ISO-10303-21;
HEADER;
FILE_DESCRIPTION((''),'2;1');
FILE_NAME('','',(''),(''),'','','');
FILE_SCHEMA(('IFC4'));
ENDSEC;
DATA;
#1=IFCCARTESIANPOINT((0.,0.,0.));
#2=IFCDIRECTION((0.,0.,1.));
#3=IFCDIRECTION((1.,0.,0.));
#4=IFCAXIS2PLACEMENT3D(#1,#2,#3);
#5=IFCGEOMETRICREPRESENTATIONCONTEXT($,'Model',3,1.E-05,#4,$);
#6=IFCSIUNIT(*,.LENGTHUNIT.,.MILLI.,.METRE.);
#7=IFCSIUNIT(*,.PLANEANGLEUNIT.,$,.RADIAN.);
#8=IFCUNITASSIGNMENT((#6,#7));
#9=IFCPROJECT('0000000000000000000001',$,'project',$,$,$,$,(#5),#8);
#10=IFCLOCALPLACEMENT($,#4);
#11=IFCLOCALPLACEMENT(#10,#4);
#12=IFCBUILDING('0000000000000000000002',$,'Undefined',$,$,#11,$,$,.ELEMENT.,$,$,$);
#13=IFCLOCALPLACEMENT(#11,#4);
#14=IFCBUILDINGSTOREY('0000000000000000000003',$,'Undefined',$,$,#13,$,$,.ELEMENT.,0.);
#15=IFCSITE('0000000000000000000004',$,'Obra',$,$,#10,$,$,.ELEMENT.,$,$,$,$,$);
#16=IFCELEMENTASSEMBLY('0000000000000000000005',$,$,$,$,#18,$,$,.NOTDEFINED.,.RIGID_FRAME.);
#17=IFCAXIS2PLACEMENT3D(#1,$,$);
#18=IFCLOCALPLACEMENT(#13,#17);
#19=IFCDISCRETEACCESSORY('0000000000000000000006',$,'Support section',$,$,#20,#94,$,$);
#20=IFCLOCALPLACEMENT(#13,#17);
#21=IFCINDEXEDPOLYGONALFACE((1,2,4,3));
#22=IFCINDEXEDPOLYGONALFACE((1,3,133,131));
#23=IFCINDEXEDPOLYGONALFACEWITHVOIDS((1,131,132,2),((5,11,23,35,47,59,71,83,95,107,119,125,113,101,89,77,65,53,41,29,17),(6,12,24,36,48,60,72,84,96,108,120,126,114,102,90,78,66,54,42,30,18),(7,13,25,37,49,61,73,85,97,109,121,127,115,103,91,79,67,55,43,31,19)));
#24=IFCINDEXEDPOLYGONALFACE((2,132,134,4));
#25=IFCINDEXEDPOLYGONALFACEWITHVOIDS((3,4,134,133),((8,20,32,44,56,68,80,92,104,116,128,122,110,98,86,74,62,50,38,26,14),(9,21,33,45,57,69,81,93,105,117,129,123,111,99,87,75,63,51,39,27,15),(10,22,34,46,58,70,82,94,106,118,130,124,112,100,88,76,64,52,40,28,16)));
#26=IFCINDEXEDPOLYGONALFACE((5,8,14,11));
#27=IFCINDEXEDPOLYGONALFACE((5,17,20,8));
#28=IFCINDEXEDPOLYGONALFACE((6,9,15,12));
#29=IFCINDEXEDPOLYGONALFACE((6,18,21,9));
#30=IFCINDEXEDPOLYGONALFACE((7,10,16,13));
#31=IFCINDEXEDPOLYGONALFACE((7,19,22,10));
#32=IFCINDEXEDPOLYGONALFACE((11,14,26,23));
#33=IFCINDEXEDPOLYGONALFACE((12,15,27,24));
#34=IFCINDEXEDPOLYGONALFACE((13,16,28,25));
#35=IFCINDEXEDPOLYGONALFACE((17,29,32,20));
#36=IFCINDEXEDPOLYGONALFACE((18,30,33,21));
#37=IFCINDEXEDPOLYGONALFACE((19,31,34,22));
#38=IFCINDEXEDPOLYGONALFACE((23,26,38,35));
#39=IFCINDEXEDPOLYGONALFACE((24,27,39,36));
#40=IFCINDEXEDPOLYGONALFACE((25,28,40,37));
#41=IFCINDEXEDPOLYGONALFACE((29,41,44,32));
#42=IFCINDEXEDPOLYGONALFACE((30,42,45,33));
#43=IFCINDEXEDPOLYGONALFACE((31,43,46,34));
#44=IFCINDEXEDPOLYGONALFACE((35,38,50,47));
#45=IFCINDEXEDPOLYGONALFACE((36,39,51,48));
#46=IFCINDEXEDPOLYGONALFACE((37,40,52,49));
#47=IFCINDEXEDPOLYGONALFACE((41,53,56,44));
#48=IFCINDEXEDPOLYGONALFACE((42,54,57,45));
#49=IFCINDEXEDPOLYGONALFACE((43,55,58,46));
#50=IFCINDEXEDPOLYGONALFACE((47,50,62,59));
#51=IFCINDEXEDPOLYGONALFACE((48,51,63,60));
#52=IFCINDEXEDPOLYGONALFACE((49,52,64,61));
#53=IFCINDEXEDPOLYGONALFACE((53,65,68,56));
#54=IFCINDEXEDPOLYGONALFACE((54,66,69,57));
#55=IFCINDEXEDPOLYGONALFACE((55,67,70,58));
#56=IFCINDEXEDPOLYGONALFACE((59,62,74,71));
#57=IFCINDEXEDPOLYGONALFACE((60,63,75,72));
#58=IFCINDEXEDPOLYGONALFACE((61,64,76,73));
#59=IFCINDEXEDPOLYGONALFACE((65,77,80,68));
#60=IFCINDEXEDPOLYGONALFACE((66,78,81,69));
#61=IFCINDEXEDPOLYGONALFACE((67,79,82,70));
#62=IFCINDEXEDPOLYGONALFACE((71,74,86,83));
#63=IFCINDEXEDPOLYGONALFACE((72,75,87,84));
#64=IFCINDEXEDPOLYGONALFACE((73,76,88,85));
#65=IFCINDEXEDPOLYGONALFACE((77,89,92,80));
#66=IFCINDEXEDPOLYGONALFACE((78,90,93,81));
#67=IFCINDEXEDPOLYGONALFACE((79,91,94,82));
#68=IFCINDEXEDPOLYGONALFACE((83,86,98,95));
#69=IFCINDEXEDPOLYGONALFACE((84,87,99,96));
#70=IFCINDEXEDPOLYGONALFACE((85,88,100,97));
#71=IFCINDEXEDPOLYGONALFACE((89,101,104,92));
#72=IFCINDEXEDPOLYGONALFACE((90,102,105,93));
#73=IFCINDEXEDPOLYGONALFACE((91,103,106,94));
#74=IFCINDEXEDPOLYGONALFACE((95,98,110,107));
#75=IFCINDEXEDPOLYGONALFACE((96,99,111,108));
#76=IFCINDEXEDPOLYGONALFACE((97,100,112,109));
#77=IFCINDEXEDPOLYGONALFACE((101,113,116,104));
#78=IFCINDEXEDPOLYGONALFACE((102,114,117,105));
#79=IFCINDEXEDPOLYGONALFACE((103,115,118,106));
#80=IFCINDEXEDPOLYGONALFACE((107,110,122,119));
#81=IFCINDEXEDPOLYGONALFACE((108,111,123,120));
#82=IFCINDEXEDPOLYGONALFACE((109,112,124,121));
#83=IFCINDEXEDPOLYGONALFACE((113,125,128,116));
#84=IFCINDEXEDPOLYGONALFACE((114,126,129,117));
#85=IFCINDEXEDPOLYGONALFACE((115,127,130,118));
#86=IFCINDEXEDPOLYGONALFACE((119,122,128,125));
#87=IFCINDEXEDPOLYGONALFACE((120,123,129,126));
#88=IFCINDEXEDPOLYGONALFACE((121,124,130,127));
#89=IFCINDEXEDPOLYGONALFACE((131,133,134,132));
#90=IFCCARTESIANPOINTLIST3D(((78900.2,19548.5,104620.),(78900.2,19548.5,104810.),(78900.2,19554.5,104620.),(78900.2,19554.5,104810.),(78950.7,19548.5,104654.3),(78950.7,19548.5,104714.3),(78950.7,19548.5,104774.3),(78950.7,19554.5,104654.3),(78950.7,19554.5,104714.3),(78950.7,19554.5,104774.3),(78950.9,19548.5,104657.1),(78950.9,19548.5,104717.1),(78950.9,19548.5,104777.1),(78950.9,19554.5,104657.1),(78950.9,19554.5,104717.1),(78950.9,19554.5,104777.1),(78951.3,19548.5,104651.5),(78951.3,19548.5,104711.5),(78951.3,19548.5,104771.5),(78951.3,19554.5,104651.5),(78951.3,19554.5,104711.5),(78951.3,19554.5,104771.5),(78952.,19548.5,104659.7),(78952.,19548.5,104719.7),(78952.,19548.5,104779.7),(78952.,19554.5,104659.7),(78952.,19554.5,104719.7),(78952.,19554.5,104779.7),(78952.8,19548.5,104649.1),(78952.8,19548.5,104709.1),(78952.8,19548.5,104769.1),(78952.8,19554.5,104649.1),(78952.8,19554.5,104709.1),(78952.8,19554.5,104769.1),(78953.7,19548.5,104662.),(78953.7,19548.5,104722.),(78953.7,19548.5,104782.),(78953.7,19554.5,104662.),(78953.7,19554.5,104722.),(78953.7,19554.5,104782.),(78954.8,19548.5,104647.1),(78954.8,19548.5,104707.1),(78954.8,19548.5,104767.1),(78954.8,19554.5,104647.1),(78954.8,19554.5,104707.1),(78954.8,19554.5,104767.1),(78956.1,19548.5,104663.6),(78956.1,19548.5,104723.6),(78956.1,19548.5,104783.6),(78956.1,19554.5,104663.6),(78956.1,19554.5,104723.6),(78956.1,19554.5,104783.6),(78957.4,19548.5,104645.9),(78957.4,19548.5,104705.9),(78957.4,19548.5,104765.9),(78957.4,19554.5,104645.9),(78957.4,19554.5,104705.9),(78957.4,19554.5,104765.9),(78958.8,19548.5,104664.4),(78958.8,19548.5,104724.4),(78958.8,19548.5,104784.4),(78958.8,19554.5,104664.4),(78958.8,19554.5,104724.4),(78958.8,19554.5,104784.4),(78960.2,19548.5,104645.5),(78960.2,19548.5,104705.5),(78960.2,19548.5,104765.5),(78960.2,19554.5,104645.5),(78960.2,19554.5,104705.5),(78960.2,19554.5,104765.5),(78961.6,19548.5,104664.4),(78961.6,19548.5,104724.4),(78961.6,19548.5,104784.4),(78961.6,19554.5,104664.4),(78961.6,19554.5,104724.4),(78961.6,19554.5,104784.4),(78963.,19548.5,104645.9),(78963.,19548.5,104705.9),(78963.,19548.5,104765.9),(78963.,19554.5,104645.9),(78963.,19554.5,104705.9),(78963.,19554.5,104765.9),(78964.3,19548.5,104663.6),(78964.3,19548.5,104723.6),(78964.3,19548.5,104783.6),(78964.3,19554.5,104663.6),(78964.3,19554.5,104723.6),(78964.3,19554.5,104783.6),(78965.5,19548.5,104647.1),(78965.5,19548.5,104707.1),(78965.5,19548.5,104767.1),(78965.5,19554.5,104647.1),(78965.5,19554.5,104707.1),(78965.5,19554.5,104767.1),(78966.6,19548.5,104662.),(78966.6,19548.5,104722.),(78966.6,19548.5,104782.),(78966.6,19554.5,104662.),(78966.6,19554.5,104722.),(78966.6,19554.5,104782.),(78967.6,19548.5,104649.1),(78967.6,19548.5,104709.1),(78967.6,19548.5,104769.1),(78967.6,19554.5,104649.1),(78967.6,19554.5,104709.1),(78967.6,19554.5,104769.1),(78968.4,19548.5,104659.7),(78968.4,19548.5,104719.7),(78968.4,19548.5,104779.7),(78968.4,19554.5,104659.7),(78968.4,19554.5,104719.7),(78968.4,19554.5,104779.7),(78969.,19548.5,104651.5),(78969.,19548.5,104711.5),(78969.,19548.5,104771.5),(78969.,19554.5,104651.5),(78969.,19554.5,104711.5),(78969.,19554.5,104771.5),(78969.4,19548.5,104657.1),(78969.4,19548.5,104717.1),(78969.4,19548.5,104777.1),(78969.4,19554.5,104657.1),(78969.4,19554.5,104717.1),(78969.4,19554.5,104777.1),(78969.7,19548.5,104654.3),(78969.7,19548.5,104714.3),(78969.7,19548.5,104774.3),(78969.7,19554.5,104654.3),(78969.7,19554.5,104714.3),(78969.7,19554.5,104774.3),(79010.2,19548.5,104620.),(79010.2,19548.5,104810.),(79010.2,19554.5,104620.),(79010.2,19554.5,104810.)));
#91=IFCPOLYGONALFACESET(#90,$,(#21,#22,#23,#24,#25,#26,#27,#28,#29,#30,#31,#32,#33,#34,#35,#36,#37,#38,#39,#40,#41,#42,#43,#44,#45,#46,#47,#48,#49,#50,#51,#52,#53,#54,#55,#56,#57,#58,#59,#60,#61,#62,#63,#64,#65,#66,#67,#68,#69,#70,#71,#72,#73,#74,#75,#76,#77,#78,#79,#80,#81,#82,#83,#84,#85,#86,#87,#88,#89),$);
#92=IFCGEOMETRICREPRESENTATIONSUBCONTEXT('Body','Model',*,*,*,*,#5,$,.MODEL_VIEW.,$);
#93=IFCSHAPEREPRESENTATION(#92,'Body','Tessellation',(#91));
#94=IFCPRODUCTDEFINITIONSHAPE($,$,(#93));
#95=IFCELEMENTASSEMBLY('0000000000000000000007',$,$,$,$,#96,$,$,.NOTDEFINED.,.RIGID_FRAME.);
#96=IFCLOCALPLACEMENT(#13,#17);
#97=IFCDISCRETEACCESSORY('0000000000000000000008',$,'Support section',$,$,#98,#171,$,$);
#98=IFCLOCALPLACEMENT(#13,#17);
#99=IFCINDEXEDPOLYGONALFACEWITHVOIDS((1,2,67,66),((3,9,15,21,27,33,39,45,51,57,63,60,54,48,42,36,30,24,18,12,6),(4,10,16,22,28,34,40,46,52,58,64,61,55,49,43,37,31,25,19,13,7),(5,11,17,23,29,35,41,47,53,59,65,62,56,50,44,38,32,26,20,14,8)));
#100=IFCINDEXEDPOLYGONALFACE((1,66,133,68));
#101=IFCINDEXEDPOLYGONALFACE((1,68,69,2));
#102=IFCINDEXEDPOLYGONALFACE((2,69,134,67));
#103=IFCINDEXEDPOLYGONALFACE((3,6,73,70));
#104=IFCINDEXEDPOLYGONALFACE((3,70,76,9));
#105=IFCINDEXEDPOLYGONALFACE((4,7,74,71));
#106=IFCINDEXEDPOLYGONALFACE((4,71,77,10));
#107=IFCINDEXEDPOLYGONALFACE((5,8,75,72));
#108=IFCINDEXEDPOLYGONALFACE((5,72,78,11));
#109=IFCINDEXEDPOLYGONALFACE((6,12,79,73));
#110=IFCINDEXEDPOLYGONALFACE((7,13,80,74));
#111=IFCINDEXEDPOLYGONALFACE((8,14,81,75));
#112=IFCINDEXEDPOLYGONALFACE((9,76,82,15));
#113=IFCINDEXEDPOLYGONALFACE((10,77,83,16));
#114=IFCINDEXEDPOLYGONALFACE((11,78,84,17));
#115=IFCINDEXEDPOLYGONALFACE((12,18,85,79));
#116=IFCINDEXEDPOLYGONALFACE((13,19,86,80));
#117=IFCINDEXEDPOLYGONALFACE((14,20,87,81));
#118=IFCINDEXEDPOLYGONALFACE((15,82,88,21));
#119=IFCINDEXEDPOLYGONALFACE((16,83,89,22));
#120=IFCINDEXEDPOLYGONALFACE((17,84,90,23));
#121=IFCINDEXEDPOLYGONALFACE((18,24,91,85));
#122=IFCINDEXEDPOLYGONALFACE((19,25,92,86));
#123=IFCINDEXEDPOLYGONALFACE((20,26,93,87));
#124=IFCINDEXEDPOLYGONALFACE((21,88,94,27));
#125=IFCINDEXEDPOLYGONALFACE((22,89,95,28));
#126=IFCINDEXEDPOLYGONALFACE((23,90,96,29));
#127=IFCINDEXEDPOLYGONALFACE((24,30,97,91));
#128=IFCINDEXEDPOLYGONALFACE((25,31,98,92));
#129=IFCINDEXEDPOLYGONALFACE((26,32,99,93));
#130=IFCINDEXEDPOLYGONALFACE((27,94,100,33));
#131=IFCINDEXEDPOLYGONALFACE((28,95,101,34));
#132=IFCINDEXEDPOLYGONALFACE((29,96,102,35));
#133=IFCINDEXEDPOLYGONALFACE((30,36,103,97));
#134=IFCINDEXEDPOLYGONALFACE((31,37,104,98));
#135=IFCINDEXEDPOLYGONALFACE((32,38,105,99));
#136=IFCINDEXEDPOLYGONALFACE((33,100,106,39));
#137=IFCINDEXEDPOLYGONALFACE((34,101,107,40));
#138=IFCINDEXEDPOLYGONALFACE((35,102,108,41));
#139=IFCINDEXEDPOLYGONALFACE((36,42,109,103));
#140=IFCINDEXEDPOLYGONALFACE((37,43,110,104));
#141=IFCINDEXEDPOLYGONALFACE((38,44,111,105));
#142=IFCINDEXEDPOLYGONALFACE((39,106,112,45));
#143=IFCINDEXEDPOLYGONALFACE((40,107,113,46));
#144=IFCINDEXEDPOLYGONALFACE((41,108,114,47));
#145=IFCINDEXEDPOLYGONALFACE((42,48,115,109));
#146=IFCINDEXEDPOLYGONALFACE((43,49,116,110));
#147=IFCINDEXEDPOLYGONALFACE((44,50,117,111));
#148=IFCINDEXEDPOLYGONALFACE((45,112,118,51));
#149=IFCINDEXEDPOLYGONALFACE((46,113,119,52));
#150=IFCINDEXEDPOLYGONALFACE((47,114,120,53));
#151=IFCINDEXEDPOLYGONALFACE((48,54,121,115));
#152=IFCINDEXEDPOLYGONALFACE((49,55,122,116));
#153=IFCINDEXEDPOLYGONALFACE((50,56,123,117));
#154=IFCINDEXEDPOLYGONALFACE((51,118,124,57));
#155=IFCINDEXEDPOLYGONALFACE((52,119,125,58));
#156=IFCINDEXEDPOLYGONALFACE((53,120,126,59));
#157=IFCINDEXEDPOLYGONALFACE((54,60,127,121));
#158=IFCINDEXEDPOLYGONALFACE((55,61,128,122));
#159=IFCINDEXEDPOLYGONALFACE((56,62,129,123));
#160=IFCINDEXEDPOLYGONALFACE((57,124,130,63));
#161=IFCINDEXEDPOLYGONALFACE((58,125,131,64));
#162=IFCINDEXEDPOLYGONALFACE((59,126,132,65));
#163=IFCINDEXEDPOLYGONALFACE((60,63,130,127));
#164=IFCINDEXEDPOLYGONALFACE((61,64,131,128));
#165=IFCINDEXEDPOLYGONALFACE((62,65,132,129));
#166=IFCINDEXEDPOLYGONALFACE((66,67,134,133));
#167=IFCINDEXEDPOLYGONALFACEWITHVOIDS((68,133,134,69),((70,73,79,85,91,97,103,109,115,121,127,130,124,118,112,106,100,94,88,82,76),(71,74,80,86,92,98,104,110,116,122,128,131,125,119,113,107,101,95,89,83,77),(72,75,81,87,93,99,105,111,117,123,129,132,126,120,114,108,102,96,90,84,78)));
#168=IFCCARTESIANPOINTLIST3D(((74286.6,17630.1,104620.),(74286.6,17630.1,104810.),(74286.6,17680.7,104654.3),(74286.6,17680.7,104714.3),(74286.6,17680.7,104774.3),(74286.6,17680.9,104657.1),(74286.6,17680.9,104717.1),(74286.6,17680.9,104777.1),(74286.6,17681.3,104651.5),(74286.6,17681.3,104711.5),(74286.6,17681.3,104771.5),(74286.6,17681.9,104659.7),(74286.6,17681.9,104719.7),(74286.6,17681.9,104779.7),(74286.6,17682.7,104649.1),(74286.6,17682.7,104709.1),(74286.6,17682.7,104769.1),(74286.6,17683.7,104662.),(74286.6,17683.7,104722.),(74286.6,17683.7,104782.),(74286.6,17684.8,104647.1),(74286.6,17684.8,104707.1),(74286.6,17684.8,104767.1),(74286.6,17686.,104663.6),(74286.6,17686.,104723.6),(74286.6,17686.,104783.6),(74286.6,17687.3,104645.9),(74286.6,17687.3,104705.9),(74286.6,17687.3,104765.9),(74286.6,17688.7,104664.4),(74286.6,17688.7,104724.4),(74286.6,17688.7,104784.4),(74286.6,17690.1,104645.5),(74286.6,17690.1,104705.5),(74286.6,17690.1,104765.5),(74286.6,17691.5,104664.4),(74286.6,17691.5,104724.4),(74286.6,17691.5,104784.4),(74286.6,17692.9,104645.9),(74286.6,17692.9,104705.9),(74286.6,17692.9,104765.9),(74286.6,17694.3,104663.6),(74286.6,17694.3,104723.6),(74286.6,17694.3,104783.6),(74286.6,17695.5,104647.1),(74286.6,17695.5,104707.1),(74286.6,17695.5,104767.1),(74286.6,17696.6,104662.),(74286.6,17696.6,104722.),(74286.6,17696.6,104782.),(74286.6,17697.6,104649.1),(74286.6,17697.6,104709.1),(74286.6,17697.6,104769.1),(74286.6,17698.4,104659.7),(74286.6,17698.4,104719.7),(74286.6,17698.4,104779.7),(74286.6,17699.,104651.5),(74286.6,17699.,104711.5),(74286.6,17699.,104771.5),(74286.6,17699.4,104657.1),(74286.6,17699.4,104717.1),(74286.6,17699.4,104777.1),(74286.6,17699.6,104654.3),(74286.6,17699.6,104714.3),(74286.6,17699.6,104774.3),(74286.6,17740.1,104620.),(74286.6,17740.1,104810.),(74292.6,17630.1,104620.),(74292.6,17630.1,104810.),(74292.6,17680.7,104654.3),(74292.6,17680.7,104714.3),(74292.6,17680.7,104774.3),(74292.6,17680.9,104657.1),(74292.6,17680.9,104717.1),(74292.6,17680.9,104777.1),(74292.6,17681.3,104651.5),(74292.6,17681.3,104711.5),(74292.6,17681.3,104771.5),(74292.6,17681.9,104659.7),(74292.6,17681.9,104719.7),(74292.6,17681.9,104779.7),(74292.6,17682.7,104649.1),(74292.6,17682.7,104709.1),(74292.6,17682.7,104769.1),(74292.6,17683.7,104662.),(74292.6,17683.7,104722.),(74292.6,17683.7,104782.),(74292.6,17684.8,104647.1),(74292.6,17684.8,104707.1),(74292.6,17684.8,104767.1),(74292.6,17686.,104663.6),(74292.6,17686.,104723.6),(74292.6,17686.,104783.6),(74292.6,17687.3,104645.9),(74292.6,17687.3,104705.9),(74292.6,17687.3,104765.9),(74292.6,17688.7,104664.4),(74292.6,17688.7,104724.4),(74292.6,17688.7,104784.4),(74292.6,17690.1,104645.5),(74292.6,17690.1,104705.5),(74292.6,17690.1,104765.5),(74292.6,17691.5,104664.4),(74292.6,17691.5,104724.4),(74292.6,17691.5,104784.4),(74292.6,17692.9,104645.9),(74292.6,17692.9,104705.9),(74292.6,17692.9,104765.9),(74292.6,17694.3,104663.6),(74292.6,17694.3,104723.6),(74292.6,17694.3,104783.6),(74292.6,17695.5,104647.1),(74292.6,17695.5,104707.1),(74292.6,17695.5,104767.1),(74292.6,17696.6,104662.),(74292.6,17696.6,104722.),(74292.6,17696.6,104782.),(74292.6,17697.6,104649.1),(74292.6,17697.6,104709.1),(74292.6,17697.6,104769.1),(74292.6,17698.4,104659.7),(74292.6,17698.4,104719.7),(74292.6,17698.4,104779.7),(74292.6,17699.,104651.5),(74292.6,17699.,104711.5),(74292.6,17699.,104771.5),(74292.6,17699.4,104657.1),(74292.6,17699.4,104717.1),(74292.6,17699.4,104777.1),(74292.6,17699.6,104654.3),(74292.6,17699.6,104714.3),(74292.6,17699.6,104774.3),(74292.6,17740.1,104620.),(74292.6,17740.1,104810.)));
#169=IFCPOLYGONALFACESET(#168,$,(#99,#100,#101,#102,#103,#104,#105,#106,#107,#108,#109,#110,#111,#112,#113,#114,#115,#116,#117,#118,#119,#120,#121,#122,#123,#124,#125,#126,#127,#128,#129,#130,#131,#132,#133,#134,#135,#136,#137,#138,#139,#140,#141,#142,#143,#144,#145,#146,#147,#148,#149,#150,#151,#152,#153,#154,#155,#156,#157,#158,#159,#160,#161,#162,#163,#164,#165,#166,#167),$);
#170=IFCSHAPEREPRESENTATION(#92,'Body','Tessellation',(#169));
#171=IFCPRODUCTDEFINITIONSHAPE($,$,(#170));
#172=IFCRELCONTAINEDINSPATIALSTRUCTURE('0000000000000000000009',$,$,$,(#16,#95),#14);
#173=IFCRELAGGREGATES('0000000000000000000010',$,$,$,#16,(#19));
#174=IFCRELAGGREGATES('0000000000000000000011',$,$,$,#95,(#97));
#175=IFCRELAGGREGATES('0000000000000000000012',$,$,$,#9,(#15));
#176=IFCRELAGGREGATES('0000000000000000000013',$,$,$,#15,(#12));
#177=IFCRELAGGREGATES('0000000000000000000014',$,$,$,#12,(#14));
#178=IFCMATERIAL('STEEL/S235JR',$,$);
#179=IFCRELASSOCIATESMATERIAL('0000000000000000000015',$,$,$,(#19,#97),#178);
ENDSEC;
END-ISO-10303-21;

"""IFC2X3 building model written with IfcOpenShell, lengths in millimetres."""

from ifc_helpers import new_model, si_unit, frame, origin_with_axes, origin_2d_with_axis, place, context, subcontext, project, spatial, rectangle, circle, extrude, source, transform, mapped, material, element, aggregate, save


model = new_model("IFC2X3")

# Units and contexts
model_context = context("Model", 3, precision=1e-05, world=origin_with_axes())
body_context = subcontext(model_context, "Body", "Model", "MODEL_VIEW")
ifc_project = project(units=[si_unit("LENGTHUNIT", "METRE", prefix="MILLI"), si_unit("PLANEANGLEUNIT", "RADIAN")], contexts=[model_context])

# Site, building, storey
site_placement = place(None, origin_with_axes())
site = spatial("IfcSite", under=ifc_project, at=site_placement, Name="Obra", CompositionType="ELEMENT")
building_placement = place(site_placement, origin_with_axes())
building = spatial("IfcBuilding", under=site, at=building_placement, Name="Undefined", CompositionType="ELEMENT")
storey_placement = place(building_placement, origin_with_axes())
storey = spatial("IfcBuildingStorey", under=building, at=storey_placement, Name="Undefined", CompositionType="ELEMENT", Elevation=0.0)

# Element assembly
assembly_1_placement = place(storey_placement, origin_with_axes())
assembly_1 = element("IfcElementAssembly", 1, at=assembly_1_placement, inside=storey, AssemblyPlace="NOTDEFINED", PredefinedType="RIGID_FRAME")
ifc_material = material(Name="STEEL/S235JR")

# Discrete accessory, opening
discrete_accessory_1_placement = place(assembly_1_placement, frame((78955.2, 19551.5, 104620.0), z_axis=(0.0, 0.0, 1.0), x_axis=(-1.0, 0.0, 0.0)))
discrete_accessory_1 = element("IfcDiscreteAccessory", 2, at=discrete_accessory_1_placement, material=ifc_material, Name="Support section", context=body_context, shape_type="SweptSolid", body=[
    extrude(rectangle(XDim=6.0, YDim=110.0, at=origin_2d_with_axis()), frame((0.0, 0.0, 190.0), z_axis=(0.0, 0.0, -1.0), x_axis=(0.0, 1.0, 0.0)), (0.0, 0.0, 1.0), 190.0),
])
shared_shape_1 = source(origin_with_axes(), body_context, "Body", "SweptSolid", [
    extrude(circle(Radius=9.5, at=origin_2d_with_axis()), frame((0.0, -9.2, 0.0), z_axis=(0.0, 1.0, 0.0), x_axis=(1.0, 0.0, 0.0)), (0.0, 0.0, 1.0), 6.2),
])
opening_1_placement = place(assembly_1_placement, frame((78910.2, 19557.6, 104835.0), z_axis=(1.0, 0.0, 0.0), x_axis=(0.0, 0.0, -1.0)))
element("IfcOpeningElement", 3, at=opening_1_placement, cuts=discrete_accessory_1, ObjectType="Opening", context=body_context, shape_type="MappedRepresentation", body=[
    mapped(shared_shape_1, transform((60.0, 0.0, 50.0))),
    mapped(shared_shape_1, transform((120.0, 0.0, 50.0))),
    mapped(shared_shape_1, transform((180.0, 0.0, 50.0))),
])
aggregate(assembly_1, [discrete_accessory_1])

# Element assembly, discrete accessory, opening
assembly_2_placement = place(storey_placement, origin_with_axes())
assembly_2 = element("IfcElementAssembly", 4, at=assembly_2_placement, inside=storey, AssemblyPlace="NOTDEFINED", PredefinedType="RIGID_FRAME")
discrete_accessory_2_placement = place(assembly_2_placement, frame((74289.6, 17685.1, 104620.0), z_axis=(0.0, 0.0, 1.0), x_axis=(0.0, -1.0, 0.0)))
discrete_accessory_2 = element("IfcDiscreteAccessory", 5, at=discrete_accessory_2_placement, material=ifc_material, Name="Support section", context=body_context, shape_type="SweptSolid", body=[
    extrude(rectangle(XDim=6.0, YDim=110.0, at=origin_2d_with_axis()), frame((0.0, 0.0, 190.0), z_axis=(0.0, 0.0, -1.0), x_axis=(0.0, 1.0, 0.0)), (0.0, 0.0, 1.0), 190.0),
])
opening_2_placement = place(assembly_2_placement, frame((74283.5, 17640.1, 104835.0), z_axis=(0.0, 1.0, 0.0), x_axis=(0.0, 0.0, -1.0)))
element("IfcOpeningElement", 6, at=opening_2_placement, cuts=discrete_accessory_2, ObjectType="Opening", context=body_context, shape_type="MappedRepresentation", body=[
    mapped(shared_shape_1, transform((60.0, 0.0, 50.0))),
    mapped(shared_shape_1, transform((120.0, 0.0, 50.0))),
    mapped(shared_shape_1, transform((180.0, 0.0, 50.0))),
])
aggregate(assembly_2, [discrete_accessory_2])

save(model, "model.ifc")
